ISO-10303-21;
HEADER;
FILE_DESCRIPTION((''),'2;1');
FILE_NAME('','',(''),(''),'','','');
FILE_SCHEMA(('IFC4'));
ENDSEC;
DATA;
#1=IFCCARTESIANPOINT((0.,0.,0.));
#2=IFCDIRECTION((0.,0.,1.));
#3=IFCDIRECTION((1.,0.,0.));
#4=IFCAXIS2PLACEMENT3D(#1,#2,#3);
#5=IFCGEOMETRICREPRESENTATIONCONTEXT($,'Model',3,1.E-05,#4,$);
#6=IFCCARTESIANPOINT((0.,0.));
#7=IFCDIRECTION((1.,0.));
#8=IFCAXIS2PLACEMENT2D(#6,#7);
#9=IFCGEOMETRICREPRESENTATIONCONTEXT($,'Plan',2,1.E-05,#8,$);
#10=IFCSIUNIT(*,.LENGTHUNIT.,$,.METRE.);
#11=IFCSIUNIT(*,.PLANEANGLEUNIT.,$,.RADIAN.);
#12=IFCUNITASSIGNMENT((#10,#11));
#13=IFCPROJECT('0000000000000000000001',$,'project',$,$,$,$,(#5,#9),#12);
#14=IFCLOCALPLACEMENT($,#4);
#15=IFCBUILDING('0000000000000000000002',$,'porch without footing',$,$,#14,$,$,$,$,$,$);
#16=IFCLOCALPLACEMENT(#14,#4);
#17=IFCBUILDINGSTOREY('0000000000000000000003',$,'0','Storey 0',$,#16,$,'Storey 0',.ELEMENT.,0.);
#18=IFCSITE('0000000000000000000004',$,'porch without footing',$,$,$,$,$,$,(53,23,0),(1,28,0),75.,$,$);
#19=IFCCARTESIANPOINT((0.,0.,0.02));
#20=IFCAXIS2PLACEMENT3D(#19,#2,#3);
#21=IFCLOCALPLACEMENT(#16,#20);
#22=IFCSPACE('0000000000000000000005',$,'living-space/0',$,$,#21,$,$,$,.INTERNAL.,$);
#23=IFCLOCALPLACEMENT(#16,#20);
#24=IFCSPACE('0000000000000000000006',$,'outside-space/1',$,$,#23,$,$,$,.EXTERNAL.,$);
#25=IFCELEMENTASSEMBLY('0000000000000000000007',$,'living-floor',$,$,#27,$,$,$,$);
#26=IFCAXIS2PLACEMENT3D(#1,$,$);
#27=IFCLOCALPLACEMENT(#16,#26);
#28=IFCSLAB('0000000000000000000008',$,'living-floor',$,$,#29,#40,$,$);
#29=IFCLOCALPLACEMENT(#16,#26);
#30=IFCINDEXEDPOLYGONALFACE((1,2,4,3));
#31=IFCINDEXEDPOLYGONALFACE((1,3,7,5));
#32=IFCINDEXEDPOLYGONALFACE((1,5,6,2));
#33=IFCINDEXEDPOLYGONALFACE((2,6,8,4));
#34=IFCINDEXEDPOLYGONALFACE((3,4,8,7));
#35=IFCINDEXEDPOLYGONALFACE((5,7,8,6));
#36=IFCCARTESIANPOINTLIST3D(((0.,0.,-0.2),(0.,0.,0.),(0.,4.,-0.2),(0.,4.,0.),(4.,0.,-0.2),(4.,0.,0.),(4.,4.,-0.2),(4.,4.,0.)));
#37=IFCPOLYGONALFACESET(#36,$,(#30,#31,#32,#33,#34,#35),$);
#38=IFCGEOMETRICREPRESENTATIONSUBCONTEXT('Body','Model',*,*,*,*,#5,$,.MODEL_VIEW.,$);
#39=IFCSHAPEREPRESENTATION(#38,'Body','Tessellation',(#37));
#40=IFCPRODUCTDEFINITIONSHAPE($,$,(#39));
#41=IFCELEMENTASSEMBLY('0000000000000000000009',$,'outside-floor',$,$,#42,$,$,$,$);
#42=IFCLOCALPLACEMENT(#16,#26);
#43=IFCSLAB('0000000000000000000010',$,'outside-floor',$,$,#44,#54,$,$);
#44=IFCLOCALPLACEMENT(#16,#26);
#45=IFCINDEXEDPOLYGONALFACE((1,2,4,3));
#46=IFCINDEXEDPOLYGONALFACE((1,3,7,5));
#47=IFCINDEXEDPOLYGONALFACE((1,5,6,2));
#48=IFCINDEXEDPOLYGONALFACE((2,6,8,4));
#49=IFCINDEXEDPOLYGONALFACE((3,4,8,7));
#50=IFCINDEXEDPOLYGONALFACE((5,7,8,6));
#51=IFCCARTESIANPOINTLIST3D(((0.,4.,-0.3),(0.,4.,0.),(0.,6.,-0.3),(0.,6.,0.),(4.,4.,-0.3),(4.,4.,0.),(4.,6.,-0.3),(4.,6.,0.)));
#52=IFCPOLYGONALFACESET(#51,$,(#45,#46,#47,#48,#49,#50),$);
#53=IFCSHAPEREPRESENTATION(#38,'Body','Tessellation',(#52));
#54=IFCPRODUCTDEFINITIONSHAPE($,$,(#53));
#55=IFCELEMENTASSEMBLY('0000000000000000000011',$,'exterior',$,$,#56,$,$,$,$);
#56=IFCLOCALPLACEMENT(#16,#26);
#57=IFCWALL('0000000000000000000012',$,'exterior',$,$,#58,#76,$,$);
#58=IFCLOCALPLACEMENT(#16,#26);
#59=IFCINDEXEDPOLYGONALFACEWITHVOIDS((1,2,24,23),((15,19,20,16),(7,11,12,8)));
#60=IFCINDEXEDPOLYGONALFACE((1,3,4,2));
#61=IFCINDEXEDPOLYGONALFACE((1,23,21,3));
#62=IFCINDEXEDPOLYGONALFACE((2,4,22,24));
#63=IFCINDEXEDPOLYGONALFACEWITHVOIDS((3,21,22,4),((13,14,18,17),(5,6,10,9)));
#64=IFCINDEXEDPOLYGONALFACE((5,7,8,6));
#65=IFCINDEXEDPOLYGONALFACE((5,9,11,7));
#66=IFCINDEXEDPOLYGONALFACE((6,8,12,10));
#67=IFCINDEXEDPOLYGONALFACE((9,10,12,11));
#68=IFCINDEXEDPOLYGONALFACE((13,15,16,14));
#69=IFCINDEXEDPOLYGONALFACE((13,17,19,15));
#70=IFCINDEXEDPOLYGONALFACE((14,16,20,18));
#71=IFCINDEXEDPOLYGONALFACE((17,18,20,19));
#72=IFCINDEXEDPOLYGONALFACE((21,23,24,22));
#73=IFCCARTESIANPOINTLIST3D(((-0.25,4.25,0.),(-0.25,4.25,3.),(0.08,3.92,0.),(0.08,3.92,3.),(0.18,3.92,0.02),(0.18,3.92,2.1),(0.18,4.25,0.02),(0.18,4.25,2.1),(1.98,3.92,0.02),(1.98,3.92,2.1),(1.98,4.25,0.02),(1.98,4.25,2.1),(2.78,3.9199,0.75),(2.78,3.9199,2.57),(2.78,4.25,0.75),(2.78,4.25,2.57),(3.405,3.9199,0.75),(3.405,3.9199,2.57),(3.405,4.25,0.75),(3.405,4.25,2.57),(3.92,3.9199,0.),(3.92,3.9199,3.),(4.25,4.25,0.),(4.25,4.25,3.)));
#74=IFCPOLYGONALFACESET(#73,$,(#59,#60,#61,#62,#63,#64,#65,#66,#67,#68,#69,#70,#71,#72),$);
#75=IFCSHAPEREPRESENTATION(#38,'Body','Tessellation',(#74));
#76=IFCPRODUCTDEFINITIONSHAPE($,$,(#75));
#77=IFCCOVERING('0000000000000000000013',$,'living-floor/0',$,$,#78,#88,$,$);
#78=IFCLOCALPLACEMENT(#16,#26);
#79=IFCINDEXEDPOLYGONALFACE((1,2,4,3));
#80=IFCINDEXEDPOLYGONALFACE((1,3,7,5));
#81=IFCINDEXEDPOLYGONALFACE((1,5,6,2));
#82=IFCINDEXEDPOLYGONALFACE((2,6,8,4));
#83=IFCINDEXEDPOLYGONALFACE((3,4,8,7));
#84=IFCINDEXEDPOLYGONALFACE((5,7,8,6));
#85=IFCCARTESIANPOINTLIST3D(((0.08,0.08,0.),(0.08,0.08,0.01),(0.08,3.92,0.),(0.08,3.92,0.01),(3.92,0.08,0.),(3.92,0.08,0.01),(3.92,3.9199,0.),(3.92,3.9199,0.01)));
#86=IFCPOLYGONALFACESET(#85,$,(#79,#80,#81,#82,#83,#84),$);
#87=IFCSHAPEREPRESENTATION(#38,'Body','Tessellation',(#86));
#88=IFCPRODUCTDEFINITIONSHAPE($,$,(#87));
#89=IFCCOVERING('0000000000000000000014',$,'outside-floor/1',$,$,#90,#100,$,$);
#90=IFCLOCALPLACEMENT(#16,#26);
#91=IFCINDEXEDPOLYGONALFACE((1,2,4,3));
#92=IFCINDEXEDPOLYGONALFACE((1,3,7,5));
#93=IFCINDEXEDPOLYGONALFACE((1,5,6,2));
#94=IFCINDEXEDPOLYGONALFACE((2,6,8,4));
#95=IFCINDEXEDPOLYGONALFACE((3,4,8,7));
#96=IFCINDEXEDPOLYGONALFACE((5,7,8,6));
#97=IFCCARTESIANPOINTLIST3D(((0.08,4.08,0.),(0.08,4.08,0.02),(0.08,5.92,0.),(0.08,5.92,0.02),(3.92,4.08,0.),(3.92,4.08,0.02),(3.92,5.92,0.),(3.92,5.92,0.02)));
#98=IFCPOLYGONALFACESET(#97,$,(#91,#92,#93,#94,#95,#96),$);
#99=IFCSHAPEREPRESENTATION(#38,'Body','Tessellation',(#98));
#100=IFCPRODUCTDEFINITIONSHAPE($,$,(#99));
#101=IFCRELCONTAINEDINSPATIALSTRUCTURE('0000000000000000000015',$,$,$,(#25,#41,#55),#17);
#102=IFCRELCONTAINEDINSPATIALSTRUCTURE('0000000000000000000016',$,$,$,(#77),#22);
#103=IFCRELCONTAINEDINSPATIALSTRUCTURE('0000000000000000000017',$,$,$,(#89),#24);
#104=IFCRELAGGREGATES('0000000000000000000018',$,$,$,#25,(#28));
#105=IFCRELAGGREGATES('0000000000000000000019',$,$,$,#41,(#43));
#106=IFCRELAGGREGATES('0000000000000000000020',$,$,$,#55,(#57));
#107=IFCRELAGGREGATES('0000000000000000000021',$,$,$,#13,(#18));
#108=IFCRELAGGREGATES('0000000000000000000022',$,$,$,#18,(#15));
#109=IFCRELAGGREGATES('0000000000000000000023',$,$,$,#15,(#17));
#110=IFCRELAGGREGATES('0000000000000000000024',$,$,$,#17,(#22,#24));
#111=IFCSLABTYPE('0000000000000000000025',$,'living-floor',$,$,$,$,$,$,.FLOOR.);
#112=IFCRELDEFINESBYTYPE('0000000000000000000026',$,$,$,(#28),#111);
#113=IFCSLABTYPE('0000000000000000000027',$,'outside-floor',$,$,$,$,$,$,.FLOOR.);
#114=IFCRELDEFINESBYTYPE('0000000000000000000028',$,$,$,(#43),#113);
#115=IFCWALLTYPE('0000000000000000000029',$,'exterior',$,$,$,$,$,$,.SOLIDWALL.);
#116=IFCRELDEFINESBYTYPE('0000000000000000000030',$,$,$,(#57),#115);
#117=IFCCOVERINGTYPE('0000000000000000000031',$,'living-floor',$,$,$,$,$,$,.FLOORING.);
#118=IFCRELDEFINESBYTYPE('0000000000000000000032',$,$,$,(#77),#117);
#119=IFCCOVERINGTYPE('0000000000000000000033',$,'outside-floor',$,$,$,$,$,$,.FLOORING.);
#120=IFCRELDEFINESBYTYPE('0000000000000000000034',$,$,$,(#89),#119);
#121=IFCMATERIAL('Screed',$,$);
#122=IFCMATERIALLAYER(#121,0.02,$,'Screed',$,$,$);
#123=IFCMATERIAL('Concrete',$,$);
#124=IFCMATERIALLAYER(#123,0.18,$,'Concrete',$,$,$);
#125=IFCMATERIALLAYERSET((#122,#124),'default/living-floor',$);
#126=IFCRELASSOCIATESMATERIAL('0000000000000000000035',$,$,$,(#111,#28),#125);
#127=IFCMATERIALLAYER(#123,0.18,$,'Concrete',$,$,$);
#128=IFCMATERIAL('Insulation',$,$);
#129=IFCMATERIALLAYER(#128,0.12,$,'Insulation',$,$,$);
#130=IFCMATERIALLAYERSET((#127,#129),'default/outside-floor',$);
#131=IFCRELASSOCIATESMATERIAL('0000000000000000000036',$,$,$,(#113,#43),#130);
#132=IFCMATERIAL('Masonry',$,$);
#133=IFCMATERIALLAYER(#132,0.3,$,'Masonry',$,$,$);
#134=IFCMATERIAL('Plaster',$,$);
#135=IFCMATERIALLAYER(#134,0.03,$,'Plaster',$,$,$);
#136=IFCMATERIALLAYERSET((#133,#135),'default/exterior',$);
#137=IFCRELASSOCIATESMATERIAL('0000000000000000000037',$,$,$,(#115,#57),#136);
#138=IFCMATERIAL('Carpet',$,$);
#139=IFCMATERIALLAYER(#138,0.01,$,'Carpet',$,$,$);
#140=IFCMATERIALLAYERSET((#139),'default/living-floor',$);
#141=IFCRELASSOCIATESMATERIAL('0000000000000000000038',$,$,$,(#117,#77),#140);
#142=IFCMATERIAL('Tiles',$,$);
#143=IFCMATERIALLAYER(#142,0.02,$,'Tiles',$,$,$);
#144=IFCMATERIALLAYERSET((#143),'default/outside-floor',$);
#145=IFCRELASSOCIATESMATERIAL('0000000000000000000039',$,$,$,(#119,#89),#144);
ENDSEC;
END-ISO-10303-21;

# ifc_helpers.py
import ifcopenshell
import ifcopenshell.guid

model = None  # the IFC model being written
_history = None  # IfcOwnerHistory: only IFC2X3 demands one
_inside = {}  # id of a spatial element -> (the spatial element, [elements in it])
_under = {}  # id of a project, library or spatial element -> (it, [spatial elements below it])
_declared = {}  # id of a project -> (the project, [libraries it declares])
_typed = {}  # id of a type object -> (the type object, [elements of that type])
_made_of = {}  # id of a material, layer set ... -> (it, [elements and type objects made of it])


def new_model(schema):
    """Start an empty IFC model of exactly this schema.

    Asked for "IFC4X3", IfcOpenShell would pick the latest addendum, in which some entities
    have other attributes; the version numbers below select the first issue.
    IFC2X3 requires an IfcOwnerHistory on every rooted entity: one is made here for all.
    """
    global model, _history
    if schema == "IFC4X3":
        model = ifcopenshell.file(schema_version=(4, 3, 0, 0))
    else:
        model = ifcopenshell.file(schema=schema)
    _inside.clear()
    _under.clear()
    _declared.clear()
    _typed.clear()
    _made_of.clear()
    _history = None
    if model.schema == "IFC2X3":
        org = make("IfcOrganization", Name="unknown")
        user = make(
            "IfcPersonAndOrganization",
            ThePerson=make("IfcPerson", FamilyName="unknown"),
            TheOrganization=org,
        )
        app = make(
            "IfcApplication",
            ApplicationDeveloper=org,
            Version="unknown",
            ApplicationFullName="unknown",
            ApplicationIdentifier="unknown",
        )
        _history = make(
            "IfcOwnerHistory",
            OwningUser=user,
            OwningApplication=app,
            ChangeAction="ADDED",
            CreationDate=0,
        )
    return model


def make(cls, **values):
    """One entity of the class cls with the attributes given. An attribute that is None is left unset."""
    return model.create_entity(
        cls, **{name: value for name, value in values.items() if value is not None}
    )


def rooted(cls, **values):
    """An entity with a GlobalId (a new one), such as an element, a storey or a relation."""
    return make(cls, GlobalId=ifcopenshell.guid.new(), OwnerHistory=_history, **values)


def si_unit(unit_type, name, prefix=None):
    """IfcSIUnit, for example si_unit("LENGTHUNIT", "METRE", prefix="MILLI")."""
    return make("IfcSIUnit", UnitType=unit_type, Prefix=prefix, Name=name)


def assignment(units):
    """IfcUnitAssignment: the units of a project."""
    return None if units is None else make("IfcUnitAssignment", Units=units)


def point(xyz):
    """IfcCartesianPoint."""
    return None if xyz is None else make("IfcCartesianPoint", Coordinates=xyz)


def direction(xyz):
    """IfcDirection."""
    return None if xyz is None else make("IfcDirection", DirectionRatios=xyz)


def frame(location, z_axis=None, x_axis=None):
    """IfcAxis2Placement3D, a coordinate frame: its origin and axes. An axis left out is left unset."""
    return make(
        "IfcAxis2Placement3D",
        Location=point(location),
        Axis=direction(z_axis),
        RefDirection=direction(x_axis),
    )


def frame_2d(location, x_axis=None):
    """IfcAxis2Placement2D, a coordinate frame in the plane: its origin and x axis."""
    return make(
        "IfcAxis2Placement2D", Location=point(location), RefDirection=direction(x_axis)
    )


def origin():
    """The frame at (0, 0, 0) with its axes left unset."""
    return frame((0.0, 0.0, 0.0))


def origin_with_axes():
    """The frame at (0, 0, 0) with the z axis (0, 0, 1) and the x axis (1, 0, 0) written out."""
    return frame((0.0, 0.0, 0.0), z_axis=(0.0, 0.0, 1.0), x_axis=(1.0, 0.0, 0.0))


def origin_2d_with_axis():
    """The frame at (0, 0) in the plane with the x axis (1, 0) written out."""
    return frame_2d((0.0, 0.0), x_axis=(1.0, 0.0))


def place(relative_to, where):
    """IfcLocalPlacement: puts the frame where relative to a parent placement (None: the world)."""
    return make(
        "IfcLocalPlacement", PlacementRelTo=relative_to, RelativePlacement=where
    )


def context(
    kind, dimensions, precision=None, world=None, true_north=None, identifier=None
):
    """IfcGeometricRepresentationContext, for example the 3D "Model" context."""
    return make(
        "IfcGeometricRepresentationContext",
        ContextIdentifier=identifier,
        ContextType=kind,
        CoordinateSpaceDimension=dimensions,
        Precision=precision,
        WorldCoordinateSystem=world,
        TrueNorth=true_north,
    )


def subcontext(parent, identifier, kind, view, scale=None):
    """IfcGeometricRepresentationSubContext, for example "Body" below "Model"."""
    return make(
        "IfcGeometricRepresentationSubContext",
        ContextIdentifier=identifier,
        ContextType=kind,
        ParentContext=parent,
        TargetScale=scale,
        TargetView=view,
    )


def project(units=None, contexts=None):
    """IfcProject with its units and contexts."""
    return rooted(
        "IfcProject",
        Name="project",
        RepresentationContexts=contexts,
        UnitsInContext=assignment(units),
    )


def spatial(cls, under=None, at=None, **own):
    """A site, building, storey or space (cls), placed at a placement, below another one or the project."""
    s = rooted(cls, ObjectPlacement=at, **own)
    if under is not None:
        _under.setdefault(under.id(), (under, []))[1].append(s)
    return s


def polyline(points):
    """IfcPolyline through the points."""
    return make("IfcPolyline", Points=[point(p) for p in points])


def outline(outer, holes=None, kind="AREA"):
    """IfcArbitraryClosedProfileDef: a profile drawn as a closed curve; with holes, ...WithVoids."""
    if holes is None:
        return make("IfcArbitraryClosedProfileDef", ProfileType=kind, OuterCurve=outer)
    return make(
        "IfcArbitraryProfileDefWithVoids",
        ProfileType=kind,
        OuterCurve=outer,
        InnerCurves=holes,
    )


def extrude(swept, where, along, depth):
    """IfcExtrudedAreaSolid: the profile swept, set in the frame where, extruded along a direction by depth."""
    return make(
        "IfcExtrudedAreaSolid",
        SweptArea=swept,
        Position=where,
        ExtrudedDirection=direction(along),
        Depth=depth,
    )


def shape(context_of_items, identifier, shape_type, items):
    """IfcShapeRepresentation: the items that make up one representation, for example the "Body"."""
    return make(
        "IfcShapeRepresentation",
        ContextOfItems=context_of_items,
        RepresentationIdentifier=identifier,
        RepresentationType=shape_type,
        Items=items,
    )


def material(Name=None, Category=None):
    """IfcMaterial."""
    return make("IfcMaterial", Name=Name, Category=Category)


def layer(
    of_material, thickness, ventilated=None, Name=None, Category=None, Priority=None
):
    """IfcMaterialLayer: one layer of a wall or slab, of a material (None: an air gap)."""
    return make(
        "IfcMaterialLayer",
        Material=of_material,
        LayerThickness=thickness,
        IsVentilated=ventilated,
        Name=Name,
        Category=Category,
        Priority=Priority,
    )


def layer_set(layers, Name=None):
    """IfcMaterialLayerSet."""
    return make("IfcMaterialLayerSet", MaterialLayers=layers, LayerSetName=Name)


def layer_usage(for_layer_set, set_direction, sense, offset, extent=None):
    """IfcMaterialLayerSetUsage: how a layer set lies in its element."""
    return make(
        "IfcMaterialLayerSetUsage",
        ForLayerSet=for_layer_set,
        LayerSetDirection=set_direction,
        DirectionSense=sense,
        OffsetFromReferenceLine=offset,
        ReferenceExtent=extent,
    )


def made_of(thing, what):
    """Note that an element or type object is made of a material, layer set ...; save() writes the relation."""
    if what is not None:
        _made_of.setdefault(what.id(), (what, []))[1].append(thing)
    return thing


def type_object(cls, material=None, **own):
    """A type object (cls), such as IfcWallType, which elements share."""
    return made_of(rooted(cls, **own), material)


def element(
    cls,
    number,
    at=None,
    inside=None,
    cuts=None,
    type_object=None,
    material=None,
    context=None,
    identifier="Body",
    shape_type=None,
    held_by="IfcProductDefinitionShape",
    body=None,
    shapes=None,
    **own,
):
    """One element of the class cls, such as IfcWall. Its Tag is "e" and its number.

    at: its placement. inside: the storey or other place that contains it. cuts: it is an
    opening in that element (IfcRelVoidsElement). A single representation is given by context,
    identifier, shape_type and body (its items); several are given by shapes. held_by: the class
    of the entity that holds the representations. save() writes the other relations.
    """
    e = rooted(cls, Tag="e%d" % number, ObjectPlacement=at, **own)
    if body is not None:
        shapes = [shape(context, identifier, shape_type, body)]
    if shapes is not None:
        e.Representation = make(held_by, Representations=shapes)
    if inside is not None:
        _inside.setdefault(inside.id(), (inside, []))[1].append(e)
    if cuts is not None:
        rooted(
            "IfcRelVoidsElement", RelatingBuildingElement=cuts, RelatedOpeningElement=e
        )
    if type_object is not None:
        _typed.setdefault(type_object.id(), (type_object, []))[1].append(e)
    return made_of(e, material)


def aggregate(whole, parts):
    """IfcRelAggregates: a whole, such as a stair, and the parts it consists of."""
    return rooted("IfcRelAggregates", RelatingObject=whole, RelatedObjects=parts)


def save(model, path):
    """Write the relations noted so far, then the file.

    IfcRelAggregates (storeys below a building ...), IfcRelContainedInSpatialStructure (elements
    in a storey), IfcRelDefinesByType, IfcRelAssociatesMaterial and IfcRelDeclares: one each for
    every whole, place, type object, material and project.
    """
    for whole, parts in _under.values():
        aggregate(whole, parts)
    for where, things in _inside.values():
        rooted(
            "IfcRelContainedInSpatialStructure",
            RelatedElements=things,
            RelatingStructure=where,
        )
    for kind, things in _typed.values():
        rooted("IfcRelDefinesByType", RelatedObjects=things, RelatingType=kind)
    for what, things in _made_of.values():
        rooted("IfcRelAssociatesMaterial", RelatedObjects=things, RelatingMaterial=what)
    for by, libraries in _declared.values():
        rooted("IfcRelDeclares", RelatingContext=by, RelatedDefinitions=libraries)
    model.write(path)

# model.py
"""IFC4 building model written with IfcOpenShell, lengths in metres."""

from ifc_helpers import new_model, si_unit, frame, origin, origin_with_axes, origin_2d_with_axis, place, context, subcontext, project, spatial, polyline, outline, extrude, material, layer, layer_set, layer_usage, type_object, element, aggregate, save


model = new_model("IFC4")

# Units and contexts
model_context = context("Model", 3, precision=1e-05, world=origin_with_axes())
plan_context = context("Plan", 2, precision=1e-05, world=origin_2d_with_axis())
body_context = subcontext(model_context, "Body", "Model", "MODEL_VIEW")
ifc_project = project(units=[si_unit("LENGTHUNIT", "METRE"), si_unit("PLANEANGLEUNIT", "RADIAN")], contexts=[model_context, plan_context])

# Site, building, storey
site = spatial("IfcSite", under=ifc_project, Name="porch without footing", RefLatitude=(53, 23, 0), RefLongitude=(1, 28, 0), RefElevation=75.0)
building_placement = place(None, origin_with_axes())
building = spatial("IfcBuilding", under=site, at=building_placement, Name="porch without footing")
storey_placement = place(building_placement, origin_with_axes())
storey = spatial("IfcBuildingStorey", under=building, at=storey_placement, Name="0", Description="Storey 0", LongName="Storey 0", CompositionType="ELEMENT", Elevation=0.0)

# Shared definitions
ifc_material_1 = material(Name="Concrete")

# Element assemblies, slabs
assembly_1_placement = place(storey_placement, origin_with_axes())
assembly_1 = element("IfcElementAssembly", 1, at=assembly_1_placement, inside=storey, Name="living-floor")
ifc_material_2 = material(Name="Screed")
ifc_layer_1 = layer(ifc_material_2, 0.02, Name="Screed")
ifc_layer_2 = layer(ifc_material_1, 0.18, Name="Concrete")
ifc_layer_set_1 = layer_set([ifc_layer_1, ifc_layer_2], Name="default/living-floor")
ifc_layer_usage_1 = layer_usage(ifc_layer_set_1, "AXIS3", "POSITIVE", 0.0)
slab_type_1 = type_object("IfcSlabType", Name="living-floor", PredefinedType="FLOOR", material=ifc_layer_set_1)
slab_1_placement = place(assembly_1_placement, frame((0.0, 0.0, -0.2), z_axis=(0.0, 0.0, -1.0), x_axis=(0.0, 1.0, 0.0)))
slab_1 = element("IfcSlab", 2, at=slab_1_placement, type_object=slab_type_1, material=ifc_layer_usage_1, Name="living-floor", context=body_context, shape_type="SweptSolid", body=[
    extrude(outline(polyline([(0.0, 0.0), (0.0, 4.0), (4.0, 4.0), (4.0, 0.0), (0.0, 0.0)])), origin(), (0.0, 0.0, -1.0), 0.2),
])
aggregate(assembly_1, [slab_1])
assembly_2_placement = place(storey_placement, origin_with_axes())
assembly_2 = element("IfcElementAssembly", 3, at=assembly_2_placement, inside=storey, Name="outside-floor")
ifc_layer_3 = layer(ifc_material_1, 0.18, Name="Concrete")
ifc_material_3 = material(Name="Insulation")
ifc_layer_4 = layer(ifc_material_3, 0.12, Name="Insulation")
ifc_layer_set_2 = layer_set([ifc_layer_3, ifc_layer_4], Name="default/outside-floor")
ifc_layer_usage_2 = layer_usage(ifc_layer_set_2, "AXIS3", "POSITIVE", 0.0)
slab_type_2 = type_object("IfcSlabType", Name="outside-floor", PredefinedType="FLOOR", material=ifc_layer_set_2)
slab_2_placement = place(assembly_2_placement, frame((4.0, 4.0, -0.3), z_axis=(0.0, 0.0, -1.0), x_axis=(0.0, 1.0, 0.0)))
slab_2 = element("IfcSlab", 4, at=slab_2_placement, type_object=slab_type_2, material=ifc_layer_usage_2, Name="outside-floor", context=body_context, shape_type="SweptSolid", body=[
    extrude(outline(polyline([(0.0, 0.0), (2.0, 0.0), (2.0, -4.0), (0.0, -4.0), (0.0, 0.0)])), origin(), (0.0, 0.0, -1.0), 0.3),
])
aggregate(assembly_2, [slab_2])

# Element assembly, wall, openings
assembly_3_placement = place(storey_placement, origin_with_axes())
assembly_3 = element("IfcElementAssembly", 5, at=assembly_3_placement, inside=storey, Name="exterior")
ifc_material_4 = material(Name="Masonry")
ifc_layer_5 = layer(ifc_material_4, 0.3, Name="Masonry")
ifc_material_5 = material(Name="Plaster")
ifc_layer_6 = layer(ifc_material_5, 0.03, Name="Plaster")
ifc_layer_set_3 = layer_set([ifc_layer_5, ifc_layer_6], Name="default/exterior")
ifc_layer_usage_3 = layer_usage(ifc_layer_set_3, "AXIS2", "POSITIVE", -0.25)
wall_type = type_object("IfcWallType", Name="exterior", PredefinedType="SOLIDWALL", material=ifc_layer_set_3)
wall_placement = place(assembly_3_placement, frame((4.0, 4.0, 0.0), z_axis=(0.0, 0.0, 1.0), x_axis=(-1.0, 0.0, 0.0)))
wall = element("IfcWall", 6, at=wall_placement, type_object=wall_type, material=ifc_layer_usage_3, Name="exterior", context=body_context, shape_type="SweptSolid", body=[
    extrude(outline(polyline([(0.08, 0.0801), (-0.25, -0.25), (4.25, -0.25), (3.92, 0.08), (0.08, 0.0801)])), origin(), (0.0, 0.0, 1.0), 3.0),
])
opening_1_placement = place(wall_placement, frame((0.595, -0.25, 0.75), z_axis=(0.0, 0.0, 1.0), x_axis=(1.0, 0.0, 0.0)))
element("IfcOpeningElement", 7, at=opening_1_placement, cuts=wall, PredefinedType="OPENING", context=body_context, shape_type="SweptSolid", body=[
    extrude(outline(polyline([(0.0, -0.02), (0.625, -0.02), (0.625, 0.35), (0.0, 0.35), (0.0, -0.02)])), origin(), (0.0, 0.0, 1.0), 1.82),
])
opening_2_placement = place(wall_placement, frame((2.02, -0.25, 0.02), z_axis=(0.0, 0.0, 1.0), x_axis=(1.0, 0.0, 0.0)))
element("IfcOpeningElement", 8, at=opening_2_placement, cuts=wall, PredefinedType="OPENING", context=body_context, shape_type="SweptSolid", body=[
    extrude(outline(polyline([(0.0, -0.02), (1.8, -0.02), (1.8, 0.35), (0.0, 0.35), (0.0, -0.02)])), origin(), (0.0, 0.0, 1.0), 2.08),
])
aggregate(assembly_3, [wall])

# Shared definitions
space_1_placement = place(storey_placement, frame((0.0, 0.0, 0.02), z_axis=(0.0, 0.0, 1.0), x_axis=(1.0, 0.0, 0.0)))
space_1 = spatial("IfcSpace", under=storey, at=space_1_placement, Name="living-space/0", PredefinedType="INTERNAL")

# Covering
ifc_material_6 = material(Name="Carpet")
ifc_layer_7 = layer(ifc_material_6, 0.01, Name="Carpet")
ifc_layer_set_4 = layer_set([ifc_layer_7], Name="default/living-floor")
ifc_layer_usage_4 = layer_usage(ifc_layer_set_4, "AXIS3", "POSITIVE", 0.0)
covering_type_1 = type_object("IfcCoveringType", Name="living-floor", PredefinedType="FLOORING", material=ifc_layer_set_4)
covering_1_placement = place(space_1_placement, frame((0.0, 0.0, -0.02), z_axis=(0.0, 0.0, 1.0), x_axis=(1.0, 0.0, 0.0)))
element("IfcCovering", 9, at=covering_1_placement, inside=space_1, type_object=covering_type_1, material=ifc_layer_usage_4, Name="living-floor/0", context=body_context, shape_type="SweptSolid", body=[
    extrude(outline(polyline([(0.08, 3.92), (0.08, 0.08), (3.92, 0.08), (3.92, 3.9199), (0.08, 3.92)])), origin_with_axes(), (0.0, 0.0, 1.0), 0.01),
])

# Shared definitions
space_2_placement = place(storey_placement, frame((0.0, 0.0, 0.02), z_axis=(0.0, 0.0, 1.0), x_axis=(1.0, 0.0, 0.0)))
space_2 = spatial("IfcSpace", under=storey, at=space_2_placement, Name="outside-space/1", PredefinedType="EXTERNAL")

# Covering
ifc_material_7 = material(Name="Tiles")
ifc_layer_8 = layer(ifc_material_7, 0.02, Name="Tiles")
ifc_layer_set_5 = layer_set([ifc_layer_8], Name="default/outside-floor")
ifc_layer_usage_5 = layer_usage(ifc_layer_set_5, "AXIS3", "POSITIVE", 0.0)
covering_type_2 = type_object("IfcCoveringType", Name="outside-floor", PredefinedType="FLOORING", material=ifc_layer_set_5)
covering_2_placement = place(space_2_placement, frame((0.0, 0.0, -0.02), z_axis=(0.0, 0.0, 1.0), x_axis=(1.0, 0.0, 0.0)))
element("IfcCovering", 10, at=covering_2_placement, inside=space_2, type_object=covering_type_2, material=ifc_layer_usage_5, Name="outside-floor/1", context=body_context, shape_type="SweptSolid", body=[
    extrude(outline(polyline([(0.08, 5.92), (0.08, 4.08), (3.92, 4.08), (3.92, 5.92), (0.08, 5.92)])), origin_with_axes(), (0.0, 0.0, 1.0), 0.02),
])

save(model, "model.ifc")
